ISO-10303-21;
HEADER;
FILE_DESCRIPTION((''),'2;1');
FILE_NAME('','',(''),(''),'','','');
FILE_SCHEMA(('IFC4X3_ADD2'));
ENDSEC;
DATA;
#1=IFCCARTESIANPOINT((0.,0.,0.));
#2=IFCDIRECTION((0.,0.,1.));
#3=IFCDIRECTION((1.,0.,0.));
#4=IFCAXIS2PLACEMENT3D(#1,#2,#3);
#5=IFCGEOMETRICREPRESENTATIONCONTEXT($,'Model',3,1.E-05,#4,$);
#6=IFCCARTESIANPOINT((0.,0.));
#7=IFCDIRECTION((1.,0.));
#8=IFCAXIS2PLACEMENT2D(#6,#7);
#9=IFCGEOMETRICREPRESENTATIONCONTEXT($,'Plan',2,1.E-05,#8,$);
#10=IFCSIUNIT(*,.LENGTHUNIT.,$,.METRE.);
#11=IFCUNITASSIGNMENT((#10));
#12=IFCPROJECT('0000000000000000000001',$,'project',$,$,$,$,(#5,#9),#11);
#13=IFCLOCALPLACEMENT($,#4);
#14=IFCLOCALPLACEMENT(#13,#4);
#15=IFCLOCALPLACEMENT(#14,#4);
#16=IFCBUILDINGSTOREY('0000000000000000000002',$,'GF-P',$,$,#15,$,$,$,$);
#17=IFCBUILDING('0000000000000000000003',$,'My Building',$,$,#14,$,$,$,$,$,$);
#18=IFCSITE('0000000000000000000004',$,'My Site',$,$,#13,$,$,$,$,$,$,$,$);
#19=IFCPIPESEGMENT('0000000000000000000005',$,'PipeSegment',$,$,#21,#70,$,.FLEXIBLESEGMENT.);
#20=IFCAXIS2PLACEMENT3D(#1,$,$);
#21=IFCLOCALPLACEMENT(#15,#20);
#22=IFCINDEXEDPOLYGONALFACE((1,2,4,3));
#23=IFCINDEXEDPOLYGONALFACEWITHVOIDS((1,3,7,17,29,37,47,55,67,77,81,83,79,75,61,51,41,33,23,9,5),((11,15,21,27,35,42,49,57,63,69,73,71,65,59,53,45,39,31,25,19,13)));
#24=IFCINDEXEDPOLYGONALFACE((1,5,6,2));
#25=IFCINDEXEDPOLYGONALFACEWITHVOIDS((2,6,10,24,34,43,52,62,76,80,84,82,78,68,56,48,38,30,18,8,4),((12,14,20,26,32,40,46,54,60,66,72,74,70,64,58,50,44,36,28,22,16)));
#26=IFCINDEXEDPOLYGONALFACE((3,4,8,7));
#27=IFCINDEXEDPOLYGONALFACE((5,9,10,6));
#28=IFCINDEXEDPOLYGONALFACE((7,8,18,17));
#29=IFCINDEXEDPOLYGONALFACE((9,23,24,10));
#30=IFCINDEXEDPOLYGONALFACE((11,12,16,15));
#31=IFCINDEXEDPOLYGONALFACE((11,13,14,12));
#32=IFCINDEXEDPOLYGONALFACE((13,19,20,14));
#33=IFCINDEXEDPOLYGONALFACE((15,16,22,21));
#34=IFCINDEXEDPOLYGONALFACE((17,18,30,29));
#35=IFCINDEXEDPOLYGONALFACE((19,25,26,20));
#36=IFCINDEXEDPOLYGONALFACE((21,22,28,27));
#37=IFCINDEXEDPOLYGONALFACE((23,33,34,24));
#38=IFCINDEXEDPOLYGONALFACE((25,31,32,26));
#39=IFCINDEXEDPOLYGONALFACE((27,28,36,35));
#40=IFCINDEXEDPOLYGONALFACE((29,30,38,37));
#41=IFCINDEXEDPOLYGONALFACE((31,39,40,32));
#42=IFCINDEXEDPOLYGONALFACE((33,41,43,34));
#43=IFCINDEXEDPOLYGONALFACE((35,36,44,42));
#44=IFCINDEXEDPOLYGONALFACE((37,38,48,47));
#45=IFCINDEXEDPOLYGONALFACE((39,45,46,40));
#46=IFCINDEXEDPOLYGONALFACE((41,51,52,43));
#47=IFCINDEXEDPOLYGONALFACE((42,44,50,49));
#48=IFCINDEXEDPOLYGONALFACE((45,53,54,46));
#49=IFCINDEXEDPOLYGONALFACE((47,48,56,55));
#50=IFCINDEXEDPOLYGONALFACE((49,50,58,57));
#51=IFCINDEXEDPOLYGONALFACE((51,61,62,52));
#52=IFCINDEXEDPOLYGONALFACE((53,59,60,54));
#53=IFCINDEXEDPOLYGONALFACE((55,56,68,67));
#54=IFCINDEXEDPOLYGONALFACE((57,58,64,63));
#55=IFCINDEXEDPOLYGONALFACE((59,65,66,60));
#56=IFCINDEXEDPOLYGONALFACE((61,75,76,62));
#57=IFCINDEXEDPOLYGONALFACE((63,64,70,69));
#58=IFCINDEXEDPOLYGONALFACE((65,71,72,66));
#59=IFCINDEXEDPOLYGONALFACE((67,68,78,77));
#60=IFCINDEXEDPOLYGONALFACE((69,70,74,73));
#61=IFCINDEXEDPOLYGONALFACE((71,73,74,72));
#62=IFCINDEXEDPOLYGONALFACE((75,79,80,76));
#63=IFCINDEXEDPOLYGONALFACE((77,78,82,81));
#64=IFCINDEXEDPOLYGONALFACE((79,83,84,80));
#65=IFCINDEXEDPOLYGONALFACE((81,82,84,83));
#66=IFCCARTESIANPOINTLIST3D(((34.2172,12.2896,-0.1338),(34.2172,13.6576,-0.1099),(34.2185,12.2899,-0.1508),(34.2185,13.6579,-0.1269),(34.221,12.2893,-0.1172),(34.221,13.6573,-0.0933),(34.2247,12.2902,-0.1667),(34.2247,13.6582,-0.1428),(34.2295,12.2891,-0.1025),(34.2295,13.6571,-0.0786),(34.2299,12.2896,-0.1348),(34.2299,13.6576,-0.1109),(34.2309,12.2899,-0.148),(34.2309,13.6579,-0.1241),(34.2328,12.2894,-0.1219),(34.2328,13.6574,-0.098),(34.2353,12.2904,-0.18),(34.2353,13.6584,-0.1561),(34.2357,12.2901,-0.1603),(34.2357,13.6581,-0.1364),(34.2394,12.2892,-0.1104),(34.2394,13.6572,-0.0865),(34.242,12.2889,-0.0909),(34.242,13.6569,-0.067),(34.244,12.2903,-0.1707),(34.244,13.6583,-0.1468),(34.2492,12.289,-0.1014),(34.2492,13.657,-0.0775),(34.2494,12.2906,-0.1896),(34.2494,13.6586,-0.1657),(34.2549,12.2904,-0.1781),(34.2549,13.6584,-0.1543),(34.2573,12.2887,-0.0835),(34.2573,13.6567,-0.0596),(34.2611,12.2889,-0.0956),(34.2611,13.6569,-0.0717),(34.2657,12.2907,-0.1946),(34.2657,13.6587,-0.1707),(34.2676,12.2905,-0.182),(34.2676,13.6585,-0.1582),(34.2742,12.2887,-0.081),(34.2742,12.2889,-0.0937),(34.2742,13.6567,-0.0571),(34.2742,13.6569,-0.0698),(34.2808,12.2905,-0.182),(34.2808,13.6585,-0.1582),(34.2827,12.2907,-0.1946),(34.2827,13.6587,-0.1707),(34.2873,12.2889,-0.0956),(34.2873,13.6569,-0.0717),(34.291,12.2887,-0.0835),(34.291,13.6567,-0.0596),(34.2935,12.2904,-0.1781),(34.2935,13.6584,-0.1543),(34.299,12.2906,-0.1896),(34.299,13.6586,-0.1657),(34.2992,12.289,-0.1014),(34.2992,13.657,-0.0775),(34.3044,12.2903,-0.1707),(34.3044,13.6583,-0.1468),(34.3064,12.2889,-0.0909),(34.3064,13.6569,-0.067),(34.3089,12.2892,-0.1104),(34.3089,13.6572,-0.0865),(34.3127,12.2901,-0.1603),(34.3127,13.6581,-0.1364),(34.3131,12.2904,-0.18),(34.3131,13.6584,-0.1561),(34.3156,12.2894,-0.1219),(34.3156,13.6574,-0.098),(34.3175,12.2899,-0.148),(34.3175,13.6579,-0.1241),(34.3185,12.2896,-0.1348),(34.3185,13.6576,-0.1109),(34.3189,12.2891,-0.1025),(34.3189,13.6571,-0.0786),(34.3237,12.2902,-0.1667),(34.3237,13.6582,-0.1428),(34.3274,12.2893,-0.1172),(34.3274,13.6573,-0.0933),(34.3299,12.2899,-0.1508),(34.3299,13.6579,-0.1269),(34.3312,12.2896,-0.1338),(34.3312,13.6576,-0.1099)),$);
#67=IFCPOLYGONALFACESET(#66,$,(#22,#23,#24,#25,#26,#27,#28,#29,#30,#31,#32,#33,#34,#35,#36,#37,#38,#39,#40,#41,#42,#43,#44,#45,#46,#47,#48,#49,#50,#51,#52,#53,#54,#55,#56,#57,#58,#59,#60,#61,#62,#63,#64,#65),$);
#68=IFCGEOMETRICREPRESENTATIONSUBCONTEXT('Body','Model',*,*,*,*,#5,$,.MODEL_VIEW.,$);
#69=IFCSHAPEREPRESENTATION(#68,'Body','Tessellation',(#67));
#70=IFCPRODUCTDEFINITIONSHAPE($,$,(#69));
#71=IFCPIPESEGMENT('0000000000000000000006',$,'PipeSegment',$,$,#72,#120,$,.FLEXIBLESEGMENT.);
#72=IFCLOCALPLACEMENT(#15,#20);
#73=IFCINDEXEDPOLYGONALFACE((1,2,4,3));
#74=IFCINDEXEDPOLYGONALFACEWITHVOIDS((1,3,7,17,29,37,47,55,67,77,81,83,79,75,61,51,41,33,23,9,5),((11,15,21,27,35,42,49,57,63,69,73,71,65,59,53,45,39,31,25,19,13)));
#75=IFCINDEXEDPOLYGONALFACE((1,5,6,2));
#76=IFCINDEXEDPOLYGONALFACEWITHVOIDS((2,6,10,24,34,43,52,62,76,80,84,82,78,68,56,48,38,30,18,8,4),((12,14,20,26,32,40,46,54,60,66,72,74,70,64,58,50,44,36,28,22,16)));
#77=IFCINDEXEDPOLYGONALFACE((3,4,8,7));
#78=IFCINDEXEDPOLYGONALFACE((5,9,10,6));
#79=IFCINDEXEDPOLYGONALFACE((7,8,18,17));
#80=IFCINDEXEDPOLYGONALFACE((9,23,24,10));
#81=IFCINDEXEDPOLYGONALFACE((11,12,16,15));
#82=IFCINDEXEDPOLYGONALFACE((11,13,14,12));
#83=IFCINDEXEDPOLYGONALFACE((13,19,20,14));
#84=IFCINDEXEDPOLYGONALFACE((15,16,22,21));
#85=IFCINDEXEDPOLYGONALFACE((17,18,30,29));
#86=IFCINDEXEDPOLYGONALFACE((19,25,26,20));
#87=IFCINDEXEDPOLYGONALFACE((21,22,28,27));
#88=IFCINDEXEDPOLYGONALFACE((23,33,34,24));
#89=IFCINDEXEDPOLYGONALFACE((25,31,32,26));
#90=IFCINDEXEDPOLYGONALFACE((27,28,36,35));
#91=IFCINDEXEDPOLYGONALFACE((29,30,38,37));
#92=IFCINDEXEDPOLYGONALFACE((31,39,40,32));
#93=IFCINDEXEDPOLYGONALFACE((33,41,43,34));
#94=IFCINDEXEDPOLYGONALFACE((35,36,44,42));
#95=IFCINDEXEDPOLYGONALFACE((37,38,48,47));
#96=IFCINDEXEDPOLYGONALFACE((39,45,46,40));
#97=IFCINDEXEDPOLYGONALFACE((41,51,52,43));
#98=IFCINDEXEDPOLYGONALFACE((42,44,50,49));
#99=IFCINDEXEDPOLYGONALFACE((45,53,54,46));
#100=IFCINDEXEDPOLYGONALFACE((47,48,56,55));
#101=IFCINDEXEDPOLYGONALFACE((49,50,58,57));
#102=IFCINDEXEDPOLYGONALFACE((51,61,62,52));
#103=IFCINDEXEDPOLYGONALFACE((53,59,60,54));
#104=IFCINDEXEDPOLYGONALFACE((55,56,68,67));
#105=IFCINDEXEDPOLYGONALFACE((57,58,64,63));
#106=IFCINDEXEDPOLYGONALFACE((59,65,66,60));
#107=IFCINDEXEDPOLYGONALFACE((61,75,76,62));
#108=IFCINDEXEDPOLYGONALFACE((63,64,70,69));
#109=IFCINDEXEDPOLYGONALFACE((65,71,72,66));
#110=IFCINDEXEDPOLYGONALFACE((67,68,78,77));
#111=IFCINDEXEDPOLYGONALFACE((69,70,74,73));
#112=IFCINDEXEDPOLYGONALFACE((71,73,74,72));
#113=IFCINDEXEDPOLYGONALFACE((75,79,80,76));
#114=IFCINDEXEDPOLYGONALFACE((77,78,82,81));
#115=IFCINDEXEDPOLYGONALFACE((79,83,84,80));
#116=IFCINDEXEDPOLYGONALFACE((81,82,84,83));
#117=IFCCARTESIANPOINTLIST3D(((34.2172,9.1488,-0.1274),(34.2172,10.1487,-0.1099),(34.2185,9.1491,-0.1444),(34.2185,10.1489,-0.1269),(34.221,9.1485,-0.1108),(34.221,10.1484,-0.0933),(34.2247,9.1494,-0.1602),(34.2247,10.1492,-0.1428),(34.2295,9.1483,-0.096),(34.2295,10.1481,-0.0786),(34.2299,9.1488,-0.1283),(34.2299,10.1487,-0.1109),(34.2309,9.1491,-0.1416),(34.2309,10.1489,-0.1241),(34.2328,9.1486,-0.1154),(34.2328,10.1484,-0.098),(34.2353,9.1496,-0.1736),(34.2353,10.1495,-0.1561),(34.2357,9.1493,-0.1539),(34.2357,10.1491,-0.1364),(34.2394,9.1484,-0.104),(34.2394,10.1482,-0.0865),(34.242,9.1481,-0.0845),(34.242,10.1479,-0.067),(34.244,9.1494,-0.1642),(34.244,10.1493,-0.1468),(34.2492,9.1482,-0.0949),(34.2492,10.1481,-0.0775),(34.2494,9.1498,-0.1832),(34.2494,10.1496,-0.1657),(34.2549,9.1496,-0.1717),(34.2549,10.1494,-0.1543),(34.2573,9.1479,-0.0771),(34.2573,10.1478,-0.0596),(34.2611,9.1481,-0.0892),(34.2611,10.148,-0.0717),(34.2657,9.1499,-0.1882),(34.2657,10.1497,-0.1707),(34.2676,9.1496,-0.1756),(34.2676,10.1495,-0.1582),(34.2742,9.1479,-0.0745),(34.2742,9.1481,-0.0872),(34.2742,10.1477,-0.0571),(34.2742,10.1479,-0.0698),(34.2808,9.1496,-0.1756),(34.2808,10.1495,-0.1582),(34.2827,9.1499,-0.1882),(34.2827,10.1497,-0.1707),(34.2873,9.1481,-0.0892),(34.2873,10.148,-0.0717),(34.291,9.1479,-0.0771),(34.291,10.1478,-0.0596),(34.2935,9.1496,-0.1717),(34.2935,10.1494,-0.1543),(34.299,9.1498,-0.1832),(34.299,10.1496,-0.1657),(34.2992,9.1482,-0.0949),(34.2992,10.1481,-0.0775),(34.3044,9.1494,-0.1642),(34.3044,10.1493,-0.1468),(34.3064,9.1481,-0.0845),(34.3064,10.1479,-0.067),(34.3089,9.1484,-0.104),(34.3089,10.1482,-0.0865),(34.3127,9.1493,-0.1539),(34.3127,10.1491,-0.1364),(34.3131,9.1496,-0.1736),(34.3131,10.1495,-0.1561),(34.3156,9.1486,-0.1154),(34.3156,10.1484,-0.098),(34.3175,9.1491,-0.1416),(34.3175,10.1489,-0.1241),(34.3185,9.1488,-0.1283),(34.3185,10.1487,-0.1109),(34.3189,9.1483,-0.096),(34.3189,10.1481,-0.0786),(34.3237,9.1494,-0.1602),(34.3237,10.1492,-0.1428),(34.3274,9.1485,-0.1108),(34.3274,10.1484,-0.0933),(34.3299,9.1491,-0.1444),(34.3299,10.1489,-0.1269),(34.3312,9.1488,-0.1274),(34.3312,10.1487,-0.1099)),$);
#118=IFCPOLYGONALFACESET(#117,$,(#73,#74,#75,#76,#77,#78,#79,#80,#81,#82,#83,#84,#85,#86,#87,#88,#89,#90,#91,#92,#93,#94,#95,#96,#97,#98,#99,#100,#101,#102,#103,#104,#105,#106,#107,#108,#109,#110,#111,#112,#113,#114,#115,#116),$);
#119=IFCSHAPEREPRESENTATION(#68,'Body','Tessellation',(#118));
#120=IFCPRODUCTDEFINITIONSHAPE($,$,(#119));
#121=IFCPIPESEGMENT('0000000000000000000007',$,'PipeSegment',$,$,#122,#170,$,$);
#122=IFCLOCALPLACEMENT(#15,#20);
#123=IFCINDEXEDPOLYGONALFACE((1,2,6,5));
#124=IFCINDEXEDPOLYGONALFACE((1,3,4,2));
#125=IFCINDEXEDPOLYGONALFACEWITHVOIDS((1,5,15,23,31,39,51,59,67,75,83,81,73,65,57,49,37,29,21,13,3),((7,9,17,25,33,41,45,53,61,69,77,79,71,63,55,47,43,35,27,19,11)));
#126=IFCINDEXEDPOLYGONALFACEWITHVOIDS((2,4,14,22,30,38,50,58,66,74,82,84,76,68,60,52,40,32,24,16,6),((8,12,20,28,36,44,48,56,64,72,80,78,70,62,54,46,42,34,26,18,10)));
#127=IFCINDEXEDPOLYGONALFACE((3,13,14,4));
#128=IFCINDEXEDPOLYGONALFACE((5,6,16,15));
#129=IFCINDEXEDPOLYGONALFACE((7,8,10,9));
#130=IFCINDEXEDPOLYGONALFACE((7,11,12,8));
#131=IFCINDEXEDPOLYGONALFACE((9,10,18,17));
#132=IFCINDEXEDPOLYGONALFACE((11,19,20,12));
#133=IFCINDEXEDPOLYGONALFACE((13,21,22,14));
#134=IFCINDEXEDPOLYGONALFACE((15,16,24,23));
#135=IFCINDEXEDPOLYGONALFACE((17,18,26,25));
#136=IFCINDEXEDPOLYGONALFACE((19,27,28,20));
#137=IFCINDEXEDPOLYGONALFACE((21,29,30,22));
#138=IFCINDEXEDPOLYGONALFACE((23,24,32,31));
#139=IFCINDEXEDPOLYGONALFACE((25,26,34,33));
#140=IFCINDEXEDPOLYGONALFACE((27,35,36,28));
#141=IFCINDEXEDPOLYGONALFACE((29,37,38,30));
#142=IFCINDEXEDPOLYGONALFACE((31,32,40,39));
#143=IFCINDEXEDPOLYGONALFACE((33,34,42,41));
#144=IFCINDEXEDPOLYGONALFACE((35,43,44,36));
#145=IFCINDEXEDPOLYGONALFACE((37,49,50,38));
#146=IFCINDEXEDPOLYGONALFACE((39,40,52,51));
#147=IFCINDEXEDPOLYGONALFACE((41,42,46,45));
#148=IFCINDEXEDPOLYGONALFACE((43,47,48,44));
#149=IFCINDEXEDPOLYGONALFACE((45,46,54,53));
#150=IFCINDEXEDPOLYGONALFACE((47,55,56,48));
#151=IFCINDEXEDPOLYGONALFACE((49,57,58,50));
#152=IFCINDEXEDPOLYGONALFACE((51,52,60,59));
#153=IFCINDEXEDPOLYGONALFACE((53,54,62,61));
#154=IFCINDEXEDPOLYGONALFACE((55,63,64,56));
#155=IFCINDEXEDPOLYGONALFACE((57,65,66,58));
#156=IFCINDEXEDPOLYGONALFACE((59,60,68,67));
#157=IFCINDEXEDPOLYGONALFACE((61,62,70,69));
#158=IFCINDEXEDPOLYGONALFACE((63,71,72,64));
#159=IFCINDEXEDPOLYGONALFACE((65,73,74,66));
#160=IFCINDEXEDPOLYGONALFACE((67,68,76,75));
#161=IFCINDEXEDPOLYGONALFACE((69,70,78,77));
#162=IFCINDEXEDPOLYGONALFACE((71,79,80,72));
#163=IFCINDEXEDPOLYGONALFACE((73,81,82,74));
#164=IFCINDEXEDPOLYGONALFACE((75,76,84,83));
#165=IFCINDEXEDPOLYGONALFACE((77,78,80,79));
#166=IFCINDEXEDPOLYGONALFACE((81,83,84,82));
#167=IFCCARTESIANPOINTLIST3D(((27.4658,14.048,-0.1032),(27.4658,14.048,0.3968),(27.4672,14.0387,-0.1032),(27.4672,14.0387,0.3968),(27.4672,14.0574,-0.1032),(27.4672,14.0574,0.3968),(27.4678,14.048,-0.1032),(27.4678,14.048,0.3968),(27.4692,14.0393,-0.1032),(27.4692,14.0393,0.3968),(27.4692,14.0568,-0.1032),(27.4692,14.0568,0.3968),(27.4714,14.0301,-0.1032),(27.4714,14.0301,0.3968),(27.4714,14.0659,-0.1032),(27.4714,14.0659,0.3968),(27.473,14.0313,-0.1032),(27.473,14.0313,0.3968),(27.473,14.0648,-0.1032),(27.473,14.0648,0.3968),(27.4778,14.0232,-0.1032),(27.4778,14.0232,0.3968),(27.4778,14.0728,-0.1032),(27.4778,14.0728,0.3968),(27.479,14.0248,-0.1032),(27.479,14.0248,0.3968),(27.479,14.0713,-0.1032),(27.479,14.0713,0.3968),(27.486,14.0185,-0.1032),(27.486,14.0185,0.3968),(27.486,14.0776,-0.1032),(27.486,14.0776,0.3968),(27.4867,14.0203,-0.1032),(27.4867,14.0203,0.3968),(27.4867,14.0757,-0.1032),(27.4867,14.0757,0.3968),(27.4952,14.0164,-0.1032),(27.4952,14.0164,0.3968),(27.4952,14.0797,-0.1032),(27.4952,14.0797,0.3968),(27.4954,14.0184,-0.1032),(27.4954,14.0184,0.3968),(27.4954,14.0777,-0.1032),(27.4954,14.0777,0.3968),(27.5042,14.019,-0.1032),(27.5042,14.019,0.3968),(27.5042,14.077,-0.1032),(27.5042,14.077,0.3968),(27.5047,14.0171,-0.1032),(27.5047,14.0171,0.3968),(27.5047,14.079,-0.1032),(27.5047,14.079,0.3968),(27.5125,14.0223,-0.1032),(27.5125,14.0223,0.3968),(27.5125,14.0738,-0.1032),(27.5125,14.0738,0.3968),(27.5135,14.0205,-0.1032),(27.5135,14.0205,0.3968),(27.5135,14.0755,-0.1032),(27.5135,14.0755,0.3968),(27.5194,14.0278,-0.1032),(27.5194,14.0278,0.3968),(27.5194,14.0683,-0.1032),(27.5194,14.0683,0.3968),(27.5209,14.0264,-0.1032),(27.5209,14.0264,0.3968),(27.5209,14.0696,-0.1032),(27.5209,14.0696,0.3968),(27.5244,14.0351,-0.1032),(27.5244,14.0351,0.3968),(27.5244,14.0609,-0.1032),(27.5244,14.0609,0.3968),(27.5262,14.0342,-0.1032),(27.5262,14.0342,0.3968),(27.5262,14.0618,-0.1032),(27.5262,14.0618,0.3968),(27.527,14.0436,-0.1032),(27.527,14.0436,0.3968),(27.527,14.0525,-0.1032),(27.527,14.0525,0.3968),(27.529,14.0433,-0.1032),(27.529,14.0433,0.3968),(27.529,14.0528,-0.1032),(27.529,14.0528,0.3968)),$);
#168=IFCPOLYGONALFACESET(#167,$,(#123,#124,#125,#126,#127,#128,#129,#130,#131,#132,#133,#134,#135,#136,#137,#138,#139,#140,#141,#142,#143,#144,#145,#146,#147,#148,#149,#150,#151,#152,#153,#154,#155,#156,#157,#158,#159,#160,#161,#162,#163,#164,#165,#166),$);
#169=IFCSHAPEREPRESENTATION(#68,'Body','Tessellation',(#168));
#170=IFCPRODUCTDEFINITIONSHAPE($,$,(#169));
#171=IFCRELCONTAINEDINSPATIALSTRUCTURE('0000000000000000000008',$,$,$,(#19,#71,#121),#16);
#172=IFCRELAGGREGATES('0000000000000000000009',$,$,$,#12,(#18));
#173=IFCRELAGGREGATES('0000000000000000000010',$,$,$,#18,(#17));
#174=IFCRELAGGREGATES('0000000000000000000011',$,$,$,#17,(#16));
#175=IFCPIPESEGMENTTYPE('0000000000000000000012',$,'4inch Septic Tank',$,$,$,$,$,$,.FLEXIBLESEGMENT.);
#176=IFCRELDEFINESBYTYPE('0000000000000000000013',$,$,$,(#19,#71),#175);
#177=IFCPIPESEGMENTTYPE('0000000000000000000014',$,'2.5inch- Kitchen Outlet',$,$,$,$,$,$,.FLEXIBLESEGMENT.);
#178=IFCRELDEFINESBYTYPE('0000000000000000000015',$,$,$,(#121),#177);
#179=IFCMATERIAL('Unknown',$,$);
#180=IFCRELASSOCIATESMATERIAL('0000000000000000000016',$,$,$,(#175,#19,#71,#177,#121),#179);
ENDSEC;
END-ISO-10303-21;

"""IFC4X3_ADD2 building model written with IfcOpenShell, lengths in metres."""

from ifc_helpers import new_model, si_unit, frame, origin_with_axes, origin_2d_with_axis, place, context, subcontext, project, spatial, hollow_circle, extrude, material, material_profile, profile_set, profile_usage, type_object, element, save


model = new_model("IFC4X3_ADD2")

# Units and contexts
model_context = context("Model", 3, precision=1e-05, world=origin_with_axes())
plan_context = context("Plan", 2, precision=1e-05, world=origin_2d_with_axis())
body_context = subcontext(model_context, "Body", "Model", "MODEL_VIEW")
ifc_project = project(units=[si_unit("LENGTHUNIT", "METRE")], contexts=[model_context, plan_context])

# Site, building, storey
site_placement = place(None, origin_with_axes())
site = spatial("IfcSite", under=ifc_project, at=site_placement, Name="My Site")
building_placement = place(site_placement, origin_with_axes())
building = spatial("IfcBuilding", under=site, at=building_placement, Name="My Building")
storey_placement = place(building_placement, origin_with_axes())
storey = spatial("IfcBuildingStorey", under=building, at=storey_placement, Name="GF-P")

# Pipe segments
ifc_material_1 = material(Name="Unknown")
ifc_material_profile_1 = material_profile(ifc_material_1, hollow_circle(Radius=0.0571, WallThickness=0.0127))
ifc_profile_set_1 = profile_set([ifc_material_profile_1], Name="blackwater")
pipe_segment_type_1 = type_object("IfcPipeSegmentType", Name="4inch Septic Tank", PredefinedType="FLEXIBLESEGMENT", material=ifc_profile_set_1)
ifc_profile_usage_1 = profile_usage(ifc_profile_set_1, cardinal=5)
pipe_segment_1_placement = place(storey_placement, frame((34.2742, 13.6577, -0.1142), z_axis=(0.0, -0.999848, -0.017452), x_axis=(0.0, -0.017452, 0.999848)))
element("IfcPipeSegment", 1, at=pipe_segment_1_placement, inside=storey, type_object=pipe_segment_type_1, material=ifc_profile_usage_1, Name="PipeSegment", PredefinedType="FLEXIBLESEGMENT", context=body_context, shape_type="SweptSolid", body=[
    extrude(hollow_circle(Radius=0.0571, WallThickness=0.0127), origin_with_axes(), (0.0, 0.0, 1.0), 1.3682),
])
ifc_profile_usage_2 = profile_usage(ifc_profile_set_1, cardinal=5)
pipe_segment_2_placement = place(storey_placement, frame((34.2742, 10.1487, -0.1142), z_axis=(0.0, -0.999848, -0.017452), x_axis=(0.0, -0.017452, 0.999848)))
element("IfcPipeSegment", 2, at=pipe_segment_2_placement, inside=storey, type_object=pipe_segment_type_1, material=ifc_profile_usage_2, Name="PipeSegment", PredefinedType="FLEXIBLESEGMENT", context=body_context, shape_type="SweptSolid", body=[
    extrude(hollow_circle(Radius=0.0571, WallThickness=0.0127), origin_with_axes(), (0.0, 0.0, 1.0), 1.0),
])
ifc_material_profile_2 = material_profile(ifc_material_1, hollow_circle(Radius=0.0318, WallThickness=0.002))
ifc_profile_set_2 = profile_set([ifc_material_profile_2], Name="kitchenwater")
ifc_profile_usage_3 = profile_usage(ifc_profile_set_2)
pipe_segment_type_2 = type_object("IfcPipeSegmentType", Name="2.5inch- Kitchen Outlet", PredefinedType="FLEXIBLESEGMENT", material=ifc_profile_set_2)
pipe_segment_3_placement = place(storey_placement, frame((27.4976, 14.048, -0.1032), z_axis=(0.0, 0.0, 1.0), x_axis=(-1.0, 0.0, 0.0)))
element("IfcPipeSegment", 3, at=pipe_segment_3_placement, inside=storey, type_object=pipe_segment_type_2, material=ifc_profile_usage_3, Name="PipeSegment", context=body_context, shape_type="SweptSolid", body=[
    extrude(hollow_circle(Radius=0.0318, WallThickness=0.002), origin_with_axes(), (0.0, 0.0, 1.0), 0.5),
])

save(model, "model.ifc")
